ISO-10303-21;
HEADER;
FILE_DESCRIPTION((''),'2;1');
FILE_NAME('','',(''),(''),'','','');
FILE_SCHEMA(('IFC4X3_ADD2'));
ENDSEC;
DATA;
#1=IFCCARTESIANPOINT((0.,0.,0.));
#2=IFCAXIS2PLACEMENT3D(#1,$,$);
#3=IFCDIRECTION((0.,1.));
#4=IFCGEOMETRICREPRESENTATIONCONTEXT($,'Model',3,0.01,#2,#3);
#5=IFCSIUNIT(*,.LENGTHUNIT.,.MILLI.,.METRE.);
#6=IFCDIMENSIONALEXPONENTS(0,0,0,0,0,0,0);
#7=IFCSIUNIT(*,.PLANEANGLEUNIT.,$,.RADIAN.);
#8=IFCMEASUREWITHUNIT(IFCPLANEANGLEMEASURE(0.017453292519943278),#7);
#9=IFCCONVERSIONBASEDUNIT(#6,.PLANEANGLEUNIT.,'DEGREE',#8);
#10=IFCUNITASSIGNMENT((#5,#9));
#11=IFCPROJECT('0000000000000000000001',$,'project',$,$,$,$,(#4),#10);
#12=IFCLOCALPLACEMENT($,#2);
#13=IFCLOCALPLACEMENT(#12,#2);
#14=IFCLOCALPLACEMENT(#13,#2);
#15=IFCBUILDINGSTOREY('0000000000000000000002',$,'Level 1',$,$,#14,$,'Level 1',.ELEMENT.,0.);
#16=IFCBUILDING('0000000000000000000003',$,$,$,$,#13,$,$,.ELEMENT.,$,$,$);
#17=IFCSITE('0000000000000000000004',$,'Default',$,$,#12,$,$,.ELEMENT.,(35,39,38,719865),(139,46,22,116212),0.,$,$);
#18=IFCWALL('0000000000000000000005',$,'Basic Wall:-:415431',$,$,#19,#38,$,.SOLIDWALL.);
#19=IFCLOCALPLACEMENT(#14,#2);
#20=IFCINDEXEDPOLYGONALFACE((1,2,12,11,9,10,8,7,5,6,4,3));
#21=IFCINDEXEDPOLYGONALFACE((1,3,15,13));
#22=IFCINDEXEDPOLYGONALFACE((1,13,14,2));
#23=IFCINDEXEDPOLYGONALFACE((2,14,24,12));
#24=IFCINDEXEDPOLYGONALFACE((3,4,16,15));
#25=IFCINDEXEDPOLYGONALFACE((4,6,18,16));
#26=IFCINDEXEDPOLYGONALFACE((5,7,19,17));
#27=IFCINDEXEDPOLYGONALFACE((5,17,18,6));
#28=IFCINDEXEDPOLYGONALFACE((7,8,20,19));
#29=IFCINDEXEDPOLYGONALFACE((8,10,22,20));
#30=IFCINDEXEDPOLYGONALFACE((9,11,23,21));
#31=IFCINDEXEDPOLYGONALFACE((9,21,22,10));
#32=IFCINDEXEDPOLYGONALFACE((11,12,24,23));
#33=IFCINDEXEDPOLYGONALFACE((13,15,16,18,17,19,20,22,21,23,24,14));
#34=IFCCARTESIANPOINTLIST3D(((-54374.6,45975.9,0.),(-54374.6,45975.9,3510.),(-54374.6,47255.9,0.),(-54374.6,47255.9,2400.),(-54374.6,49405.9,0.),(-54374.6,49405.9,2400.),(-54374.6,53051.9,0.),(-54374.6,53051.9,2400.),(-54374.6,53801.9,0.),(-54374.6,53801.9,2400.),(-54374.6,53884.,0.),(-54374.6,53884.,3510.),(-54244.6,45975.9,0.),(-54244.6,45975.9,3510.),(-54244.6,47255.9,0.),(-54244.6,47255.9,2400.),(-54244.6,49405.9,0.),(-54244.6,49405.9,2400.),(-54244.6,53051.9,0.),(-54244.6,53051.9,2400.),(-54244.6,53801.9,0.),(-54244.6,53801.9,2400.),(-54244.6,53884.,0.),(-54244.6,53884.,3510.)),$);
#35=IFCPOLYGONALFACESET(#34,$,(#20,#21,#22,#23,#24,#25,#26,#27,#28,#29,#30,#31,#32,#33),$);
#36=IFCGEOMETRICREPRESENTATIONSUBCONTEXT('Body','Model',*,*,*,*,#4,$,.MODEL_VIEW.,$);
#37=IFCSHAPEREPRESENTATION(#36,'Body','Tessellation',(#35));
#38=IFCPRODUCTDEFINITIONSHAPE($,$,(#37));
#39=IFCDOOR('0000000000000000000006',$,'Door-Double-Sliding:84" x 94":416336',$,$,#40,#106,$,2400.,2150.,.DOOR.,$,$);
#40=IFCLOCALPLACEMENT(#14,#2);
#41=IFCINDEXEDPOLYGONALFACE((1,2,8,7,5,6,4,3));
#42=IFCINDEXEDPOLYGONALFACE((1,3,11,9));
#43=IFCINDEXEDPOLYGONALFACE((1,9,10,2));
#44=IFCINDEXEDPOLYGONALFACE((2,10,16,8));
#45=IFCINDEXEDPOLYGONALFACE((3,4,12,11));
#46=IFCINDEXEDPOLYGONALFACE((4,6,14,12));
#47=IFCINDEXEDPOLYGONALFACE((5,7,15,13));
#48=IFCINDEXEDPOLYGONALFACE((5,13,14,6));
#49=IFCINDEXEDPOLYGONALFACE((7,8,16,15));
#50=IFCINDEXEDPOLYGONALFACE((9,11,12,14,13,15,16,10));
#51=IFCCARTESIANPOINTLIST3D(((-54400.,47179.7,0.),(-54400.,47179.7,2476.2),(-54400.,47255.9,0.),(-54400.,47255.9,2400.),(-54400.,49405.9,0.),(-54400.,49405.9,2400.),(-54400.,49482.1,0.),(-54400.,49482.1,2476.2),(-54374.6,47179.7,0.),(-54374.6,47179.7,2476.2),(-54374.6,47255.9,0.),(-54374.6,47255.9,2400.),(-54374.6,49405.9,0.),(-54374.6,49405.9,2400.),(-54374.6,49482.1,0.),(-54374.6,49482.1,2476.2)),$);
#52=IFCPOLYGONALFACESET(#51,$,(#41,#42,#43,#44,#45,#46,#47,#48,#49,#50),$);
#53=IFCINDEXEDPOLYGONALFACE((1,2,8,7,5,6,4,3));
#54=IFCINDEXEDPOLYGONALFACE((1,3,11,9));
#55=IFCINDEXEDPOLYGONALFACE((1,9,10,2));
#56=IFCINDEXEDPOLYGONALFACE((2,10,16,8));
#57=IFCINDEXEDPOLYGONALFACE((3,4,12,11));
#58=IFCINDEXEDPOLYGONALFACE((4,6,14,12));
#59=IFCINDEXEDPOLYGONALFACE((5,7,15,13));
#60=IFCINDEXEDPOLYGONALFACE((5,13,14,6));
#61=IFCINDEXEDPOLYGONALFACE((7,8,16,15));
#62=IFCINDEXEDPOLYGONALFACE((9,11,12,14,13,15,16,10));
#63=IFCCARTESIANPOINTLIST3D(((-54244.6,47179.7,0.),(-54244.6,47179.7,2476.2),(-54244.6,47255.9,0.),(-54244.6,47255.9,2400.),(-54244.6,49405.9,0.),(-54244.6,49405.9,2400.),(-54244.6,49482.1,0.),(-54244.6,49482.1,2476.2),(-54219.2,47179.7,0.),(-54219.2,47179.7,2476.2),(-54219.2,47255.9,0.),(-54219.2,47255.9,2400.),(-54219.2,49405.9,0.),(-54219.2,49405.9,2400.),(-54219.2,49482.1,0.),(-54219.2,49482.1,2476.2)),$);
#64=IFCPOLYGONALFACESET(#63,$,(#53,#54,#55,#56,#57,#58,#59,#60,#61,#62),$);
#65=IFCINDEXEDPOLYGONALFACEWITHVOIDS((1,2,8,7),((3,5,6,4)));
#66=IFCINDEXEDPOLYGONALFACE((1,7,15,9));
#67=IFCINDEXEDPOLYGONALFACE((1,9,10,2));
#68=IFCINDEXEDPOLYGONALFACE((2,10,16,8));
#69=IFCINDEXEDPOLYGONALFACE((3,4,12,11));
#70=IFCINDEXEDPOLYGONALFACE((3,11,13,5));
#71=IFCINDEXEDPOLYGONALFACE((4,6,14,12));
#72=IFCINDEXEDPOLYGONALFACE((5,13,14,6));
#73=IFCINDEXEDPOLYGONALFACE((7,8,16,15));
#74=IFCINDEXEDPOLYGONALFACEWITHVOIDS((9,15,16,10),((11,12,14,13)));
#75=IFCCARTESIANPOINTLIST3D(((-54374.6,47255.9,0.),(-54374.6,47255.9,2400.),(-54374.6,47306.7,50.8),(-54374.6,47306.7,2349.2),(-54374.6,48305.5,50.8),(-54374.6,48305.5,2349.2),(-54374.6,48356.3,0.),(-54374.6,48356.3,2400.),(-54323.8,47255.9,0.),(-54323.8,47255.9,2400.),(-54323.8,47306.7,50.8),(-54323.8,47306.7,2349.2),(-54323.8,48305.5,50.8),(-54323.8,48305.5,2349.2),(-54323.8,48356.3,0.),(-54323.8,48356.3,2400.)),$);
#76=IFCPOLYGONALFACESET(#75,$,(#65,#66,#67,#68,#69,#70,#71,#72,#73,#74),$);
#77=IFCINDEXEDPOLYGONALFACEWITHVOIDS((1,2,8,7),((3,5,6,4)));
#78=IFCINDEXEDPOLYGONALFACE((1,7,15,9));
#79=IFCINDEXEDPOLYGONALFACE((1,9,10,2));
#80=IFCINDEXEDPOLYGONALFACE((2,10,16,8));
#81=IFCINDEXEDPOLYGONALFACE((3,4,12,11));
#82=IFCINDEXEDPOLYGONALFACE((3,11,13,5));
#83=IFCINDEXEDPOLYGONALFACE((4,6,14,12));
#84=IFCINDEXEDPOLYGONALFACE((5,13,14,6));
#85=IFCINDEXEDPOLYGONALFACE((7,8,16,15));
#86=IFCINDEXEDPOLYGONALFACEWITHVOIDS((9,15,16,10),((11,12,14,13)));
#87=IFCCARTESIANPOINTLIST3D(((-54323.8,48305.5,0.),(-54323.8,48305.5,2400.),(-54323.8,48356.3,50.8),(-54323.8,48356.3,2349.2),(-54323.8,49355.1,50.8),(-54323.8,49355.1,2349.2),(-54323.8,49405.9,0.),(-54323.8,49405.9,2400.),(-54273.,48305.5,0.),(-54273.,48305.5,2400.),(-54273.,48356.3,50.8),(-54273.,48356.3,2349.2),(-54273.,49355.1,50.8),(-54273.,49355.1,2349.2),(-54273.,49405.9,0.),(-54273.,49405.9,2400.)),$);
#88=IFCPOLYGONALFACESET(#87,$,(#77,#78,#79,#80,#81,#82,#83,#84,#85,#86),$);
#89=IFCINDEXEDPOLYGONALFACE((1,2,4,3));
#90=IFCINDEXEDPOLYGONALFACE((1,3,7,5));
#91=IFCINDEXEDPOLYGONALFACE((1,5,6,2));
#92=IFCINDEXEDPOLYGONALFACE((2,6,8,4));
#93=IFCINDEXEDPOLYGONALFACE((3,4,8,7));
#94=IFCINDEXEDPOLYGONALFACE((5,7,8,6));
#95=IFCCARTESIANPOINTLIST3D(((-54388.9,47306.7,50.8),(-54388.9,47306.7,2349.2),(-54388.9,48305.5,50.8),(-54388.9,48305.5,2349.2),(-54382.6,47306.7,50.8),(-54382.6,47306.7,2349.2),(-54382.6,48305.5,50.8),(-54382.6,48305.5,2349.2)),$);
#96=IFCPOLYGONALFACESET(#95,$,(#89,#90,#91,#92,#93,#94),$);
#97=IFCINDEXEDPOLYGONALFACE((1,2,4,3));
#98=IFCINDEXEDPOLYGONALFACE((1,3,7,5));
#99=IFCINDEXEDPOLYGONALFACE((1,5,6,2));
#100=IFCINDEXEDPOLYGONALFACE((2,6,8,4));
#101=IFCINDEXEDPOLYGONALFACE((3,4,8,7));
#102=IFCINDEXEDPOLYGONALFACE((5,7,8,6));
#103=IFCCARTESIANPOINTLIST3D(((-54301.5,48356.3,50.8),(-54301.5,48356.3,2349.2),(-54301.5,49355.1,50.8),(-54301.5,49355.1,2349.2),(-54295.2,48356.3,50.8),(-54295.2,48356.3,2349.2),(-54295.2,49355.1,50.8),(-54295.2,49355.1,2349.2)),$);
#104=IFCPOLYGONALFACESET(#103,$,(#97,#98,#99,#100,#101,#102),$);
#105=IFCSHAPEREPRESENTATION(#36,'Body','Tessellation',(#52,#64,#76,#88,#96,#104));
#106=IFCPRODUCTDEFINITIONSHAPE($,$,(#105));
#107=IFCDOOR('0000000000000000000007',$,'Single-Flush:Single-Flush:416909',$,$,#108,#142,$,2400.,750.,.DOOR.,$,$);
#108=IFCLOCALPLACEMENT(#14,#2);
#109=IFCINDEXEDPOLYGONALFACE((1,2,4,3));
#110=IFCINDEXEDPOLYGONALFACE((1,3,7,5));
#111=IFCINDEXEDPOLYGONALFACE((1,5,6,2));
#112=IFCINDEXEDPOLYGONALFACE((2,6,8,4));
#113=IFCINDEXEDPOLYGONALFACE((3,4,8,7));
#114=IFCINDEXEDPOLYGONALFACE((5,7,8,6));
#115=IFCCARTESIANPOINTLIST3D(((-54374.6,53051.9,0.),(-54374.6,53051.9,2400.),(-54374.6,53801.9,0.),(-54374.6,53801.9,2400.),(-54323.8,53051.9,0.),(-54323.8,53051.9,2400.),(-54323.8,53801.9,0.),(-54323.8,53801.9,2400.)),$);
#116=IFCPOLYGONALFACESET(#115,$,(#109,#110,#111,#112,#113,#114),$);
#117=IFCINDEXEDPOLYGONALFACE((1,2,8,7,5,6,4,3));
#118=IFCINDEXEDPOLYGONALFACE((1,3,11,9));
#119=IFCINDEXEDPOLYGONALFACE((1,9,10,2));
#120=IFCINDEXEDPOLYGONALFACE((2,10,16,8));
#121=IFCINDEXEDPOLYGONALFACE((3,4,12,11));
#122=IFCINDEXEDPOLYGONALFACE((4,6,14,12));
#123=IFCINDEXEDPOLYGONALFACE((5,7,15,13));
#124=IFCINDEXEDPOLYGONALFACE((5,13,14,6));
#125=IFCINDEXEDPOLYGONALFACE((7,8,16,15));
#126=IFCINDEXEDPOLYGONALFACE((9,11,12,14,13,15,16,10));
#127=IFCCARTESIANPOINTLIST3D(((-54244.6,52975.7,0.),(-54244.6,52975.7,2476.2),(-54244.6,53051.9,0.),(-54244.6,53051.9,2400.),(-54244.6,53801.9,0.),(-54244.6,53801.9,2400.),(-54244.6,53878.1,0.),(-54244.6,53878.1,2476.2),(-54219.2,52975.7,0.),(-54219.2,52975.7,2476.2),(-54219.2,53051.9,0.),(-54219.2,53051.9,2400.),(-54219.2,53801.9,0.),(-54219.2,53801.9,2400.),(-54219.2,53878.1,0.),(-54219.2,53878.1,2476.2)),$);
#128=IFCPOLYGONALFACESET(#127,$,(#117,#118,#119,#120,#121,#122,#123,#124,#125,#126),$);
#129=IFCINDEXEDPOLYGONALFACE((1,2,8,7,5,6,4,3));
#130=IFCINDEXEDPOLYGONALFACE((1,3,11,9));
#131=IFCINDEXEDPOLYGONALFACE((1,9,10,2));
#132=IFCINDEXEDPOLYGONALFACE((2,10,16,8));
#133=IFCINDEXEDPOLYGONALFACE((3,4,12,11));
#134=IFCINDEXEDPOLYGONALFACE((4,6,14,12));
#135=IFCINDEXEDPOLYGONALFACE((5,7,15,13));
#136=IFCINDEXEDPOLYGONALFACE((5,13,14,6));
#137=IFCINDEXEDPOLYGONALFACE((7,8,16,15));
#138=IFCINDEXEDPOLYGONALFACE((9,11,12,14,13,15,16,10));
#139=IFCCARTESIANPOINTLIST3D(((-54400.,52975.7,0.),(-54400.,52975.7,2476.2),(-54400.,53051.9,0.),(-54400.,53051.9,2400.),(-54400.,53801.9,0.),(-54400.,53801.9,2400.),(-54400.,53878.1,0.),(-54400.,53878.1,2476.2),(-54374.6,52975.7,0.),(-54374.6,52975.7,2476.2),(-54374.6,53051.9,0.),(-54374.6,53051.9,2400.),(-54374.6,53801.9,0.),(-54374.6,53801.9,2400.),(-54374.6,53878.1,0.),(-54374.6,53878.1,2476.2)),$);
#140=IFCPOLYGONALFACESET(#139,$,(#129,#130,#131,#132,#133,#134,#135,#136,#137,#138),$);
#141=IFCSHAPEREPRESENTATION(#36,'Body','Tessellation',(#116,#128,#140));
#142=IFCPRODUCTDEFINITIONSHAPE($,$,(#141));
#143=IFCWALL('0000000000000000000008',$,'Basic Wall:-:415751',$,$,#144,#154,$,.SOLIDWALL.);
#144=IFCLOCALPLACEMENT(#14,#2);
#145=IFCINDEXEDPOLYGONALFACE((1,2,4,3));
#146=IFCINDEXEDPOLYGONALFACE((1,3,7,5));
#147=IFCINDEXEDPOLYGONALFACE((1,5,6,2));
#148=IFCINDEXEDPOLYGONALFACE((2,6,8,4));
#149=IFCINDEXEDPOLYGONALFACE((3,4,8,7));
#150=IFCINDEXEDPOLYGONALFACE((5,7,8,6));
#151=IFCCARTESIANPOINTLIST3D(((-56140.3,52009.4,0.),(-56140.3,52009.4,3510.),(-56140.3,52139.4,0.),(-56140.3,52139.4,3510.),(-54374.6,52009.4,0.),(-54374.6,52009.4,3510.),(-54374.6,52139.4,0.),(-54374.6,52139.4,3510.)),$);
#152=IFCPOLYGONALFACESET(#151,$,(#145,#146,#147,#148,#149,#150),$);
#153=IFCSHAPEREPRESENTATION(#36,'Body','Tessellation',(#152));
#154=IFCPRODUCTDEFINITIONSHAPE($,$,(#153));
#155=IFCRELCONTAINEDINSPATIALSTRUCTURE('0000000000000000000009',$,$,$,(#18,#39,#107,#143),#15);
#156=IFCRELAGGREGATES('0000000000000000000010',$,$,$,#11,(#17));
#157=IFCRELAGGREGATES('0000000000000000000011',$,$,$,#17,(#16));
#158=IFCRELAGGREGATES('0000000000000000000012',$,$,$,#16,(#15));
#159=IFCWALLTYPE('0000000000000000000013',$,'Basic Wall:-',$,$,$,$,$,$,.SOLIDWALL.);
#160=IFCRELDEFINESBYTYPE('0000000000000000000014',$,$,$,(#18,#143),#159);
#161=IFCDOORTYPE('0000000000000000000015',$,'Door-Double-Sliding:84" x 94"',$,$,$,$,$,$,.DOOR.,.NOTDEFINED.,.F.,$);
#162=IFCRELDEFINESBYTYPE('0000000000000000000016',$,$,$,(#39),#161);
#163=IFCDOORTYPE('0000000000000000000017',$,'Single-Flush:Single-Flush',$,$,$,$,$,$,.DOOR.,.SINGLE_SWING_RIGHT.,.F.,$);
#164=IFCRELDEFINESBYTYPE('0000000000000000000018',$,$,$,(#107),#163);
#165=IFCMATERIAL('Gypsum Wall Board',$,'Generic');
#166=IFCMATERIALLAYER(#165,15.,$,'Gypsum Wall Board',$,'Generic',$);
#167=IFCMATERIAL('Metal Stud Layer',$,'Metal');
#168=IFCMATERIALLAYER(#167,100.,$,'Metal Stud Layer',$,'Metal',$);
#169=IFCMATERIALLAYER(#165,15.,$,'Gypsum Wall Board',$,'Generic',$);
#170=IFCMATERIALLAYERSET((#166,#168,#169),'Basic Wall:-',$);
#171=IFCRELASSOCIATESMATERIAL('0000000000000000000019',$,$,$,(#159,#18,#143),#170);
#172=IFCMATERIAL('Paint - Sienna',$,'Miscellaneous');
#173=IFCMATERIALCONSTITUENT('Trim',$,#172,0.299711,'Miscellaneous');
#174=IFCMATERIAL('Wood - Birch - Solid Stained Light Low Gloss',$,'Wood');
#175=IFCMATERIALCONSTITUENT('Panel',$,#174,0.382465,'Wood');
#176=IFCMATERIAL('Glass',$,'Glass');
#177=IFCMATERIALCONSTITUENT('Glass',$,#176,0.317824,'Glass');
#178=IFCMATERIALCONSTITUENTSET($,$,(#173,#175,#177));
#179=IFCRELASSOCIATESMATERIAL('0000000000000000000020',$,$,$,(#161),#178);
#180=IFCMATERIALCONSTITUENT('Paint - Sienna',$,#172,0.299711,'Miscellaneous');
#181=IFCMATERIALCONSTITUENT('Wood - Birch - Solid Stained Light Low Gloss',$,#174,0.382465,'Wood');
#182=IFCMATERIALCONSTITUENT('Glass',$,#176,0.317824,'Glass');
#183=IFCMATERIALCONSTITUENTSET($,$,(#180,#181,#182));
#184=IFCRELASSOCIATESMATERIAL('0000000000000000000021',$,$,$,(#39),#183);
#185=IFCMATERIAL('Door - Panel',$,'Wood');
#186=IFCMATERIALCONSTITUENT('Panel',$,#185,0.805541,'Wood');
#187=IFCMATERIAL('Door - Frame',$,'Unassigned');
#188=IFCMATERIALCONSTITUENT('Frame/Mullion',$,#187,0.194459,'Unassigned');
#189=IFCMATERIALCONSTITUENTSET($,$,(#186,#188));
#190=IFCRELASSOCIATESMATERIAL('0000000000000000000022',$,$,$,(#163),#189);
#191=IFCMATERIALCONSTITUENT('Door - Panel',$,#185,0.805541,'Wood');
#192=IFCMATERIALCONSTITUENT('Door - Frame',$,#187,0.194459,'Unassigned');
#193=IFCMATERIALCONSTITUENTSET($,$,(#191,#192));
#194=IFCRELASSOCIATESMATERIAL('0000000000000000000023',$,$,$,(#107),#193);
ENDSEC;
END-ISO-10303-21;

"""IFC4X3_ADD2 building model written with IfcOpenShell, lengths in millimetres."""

from ifc_helpers import new_model, entity, si_unit, converted_unit, direction, frame, frame_2d, origin, origin_2d_with_axis, place, context, subcontext, project, spatial, polyline, rectangle, outline, extrude, source, transform, mapped, material, layer, layer_set, constituent, constituent_set, type_object, type_shapes, element, fill, save


model = new_model("IFC4X3_ADD2")

# Units and contexts
model_context = context("Model", 3, precision=0.01, world=origin(), true_north=direction((0.0, 1.0)))
body_context = subcontext(model_context, "Body", "Model", "MODEL_VIEW")
ifc_project = project(units=[si_unit("LENGTHUNIT", "METRE", prefix="MILLI"), converted_unit("PLANEANGLEUNIT", "DEGREE", entity("IfcPlaneAngleMeasure", 0.017453292519943278), si_unit("PLANEANGLEUNIT", "RADIAN"), dimensions=[0, 0, 0, 0, 0, 0, 0])], contexts=[model_context])

# Site, building, storey
site_placement = place(None, origin())
site = spatial("IfcSite", under=ifc_project, at=site_placement, Name="Default", CompositionType="ELEMENT", RefLatitude=(35, 39, 38, 719865), RefLongitude=(139, 46, 22, 116212), RefElevation=0.0)
building_placement = place(site_placement, origin())
building = spatial("IfcBuilding", under=site, at=building_placement, CompositionType="ELEMENT")
storey_placement = place(building_placement, origin())
storey = spatial("IfcBuildingStorey", under=building, at=storey_placement, Name="Level 1", LongName="Level 1", CompositionType="ELEMENT", Elevation=0.0)

# Shared definitions
ifc_material_1 = material(Name="Glass", Category="Glass")

# Wall, openings, doors
ifc_material_2 = material(Name="Gypsum Wall Board", Category="Generic")
ifc_layer_1 = layer(ifc_material_2, 15.0, Name="Gypsum Wall Board", Category="Generic")
ifc_material_3 = material(Name="Metal Stud Layer", Category="Metal")
ifc_layer_2 = layer(ifc_material_3, 100.0, Name="Metal Stud Layer", Category="Metal")
ifc_layer_3 = layer(ifc_material_2, 15.0, Name="Gypsum Wall Board", Category="Generic")
ifc_layer_set_1 = layer_set([ifc_layer_1, ifc_layer_2, ifc_layer_3], Name="Basic Wall:-")
wall_type = type_object("IfcWallType", Name="Basic Wall:-", PredefinedType="SOLIDWALL", material=ifc_layer_set_1)
wall_1_placement = place(storey_placement, frame((-54309.6, 45975.9, 0.0), z_axis=(0.0, 0.0, 1.0), x_axis=(0.0, 1.0, 0.0)))
wall_1 = element("IfcWall", 1, at=wall_1_placement, inside=storey, type_object=wall_type, material=ifc_layer_set_1, Name="Basic Wall:-:415431", PredefinedType="SOLIDWALL", context=body_context, shape_type="SweptSolid", body=[
    extrude(rectangle(XDim=7908.1, YDim=130.0, at=frame_2d((3954.1, 0.0), x_axis=(-1.0, 0.0))), origin(), (0.0, 0.0, 1.0), 3510.0),
])
opening_1_placement = place(wall_1_placement, frame((1280.0, -65.0, 0.0)))
opening_1 = element("IfcOpeningElement", 2, at=opening_1_placement, cuts=wall_1, PredefinedType="OPENING", context=body_context, shape_type="SweptSolid", body=[
    extrude(rectangle(XDim=2400.0, YDim=2150.0, at=frame_2d((1200.0, 1075.0), x_axis=(-1.0, 0.0))), frame((0.0, 0.0, 0.0), z_axis=(0.0, 1.0, 0.0), x_axis=(0.0, 0.0, 1.0)), (0.0, 0.0, 1.0), 130.0),
])
opening_2_placement = place(wall_1_placement, frame((7075.9, -65.0, 0.0)))
opening_2 = element("IfcOpeningElement", 3, at=opening_2_placement, cuts=wall_1, PredefinedType="OPENING", context=body_context, shape_type="SweptSolid", body=[
    extrude(rectangle(XDim=750.0, YDim=2400.0, at=frame_2d((1200.0, 375.0), x_axis=(0.0, 1.0))), frame((0.0, 0.0, 0.0), z_axis=(0.0, 1.0, 0.0), x_axis=(0.0, 0.0, 1.0)), (0.0, 0.0, 1.0), 130.0),
])
ifc_material_4 = material(Name="Paint - Sienna", Category="Miscellaneous")
ifc_constituent_1 = constituent(ifc_material_4, Name="Paint - Sienna", Category="Miscellaneous", fraction=0.299711)
ifc_material_5 = material(Name="Wood - Birch - Solid Stained Light Low Gloss", Category="Wood")
ifc_constituent_2 = constituent(ifc_material_5, Name="Wood - Birch - Solid Stained Light Low Gloss", Category="Wood", fraction=0.382465)
ifc_constituent_3 = constituent(ifc_material_1, Name="Glass", Category="Glass", fraction=0.317824)
ifc_constituent_set_1 = constituent_set(constituents=[ifc_constituent_1, ifc_constituent_2, ifc_constituent_3])
ifc_constituent_4 = constituent(ifc_material_4, Name="Trim", Category="Miscellaneous", fraction=0.299711)
ifc_constituent_5 = constituent(ifc_material_5, Name="Panel", Category="Wood", fraction=0.382465)
ifc_constituent_6 = constituent(ifc_material_1, Name="Glass", Category="Glass", fraction=0.317824)
ifc_constituent_set_2 = constituent_set(constituents=[ifc_constituent_4, ifc_constituent_5, ifc_constituent_6])
door_type_1 = type_object("IfcDoorType", Name="Door-Double-Sliding:84\" x 94\"", OperationType="NOTDEFINED", ParameterTakesPrecedence=False, PredefinedType="DOOR", material=ifc_constituent_set_2)
shared_shape_1 = source(origin(), body_context, "Body", "SweptSolid", [
    extrude(outline(polyline([(-1151.2, -1219.0), (-1075.0, -1219.0), (-1075.0, 1181.0), (1075.0, 1180.9), (1075.0, -1219.1), (1151.2, -1219.1), (1151.2, 1257.1), (-1151.2, 1257.2), (-1151.2, -1219.0)])), frame((1075.0, 130.0, 1219.0), z_axis=(0.0, 1.0, 0.0), x_axis=(-1.0, 0.0, 0.0)), (0.0, 0.0, 1.0), 25.4),
    extrude(outline(polyline([(-1219.0, -1151.2), (1257.1, -1151.2), (1257.1, 1151.2), (-1219.0, 1151.2), (-1219.0, 1075.0), (1180.9, 1075.0), (1180.9, -1075.0), (-1219.0, -1075.0), (-1219.0, -1151.2)])), frame((1075.0, -25.4, 1219.0), z_axis=(0.0, 1.0, 0.0), x_axis=(0.0, 0.0, 1.0)), (0.0, 0.0, 1.0), 25.4),
    extrude(outline(polyline([(-1200.0, -550.2), (1200.0, -550.2), (1200.0, 550.2), (-1200.0, 550.2), (-1200.0, -550.2)]), holes=[polyline([(-1149.2, -499.4), (-1149.2, 499.4), (1149.2, 499.4), (1149.2, -499.4), (-1149.2, -499.4)])]), frame((550.2, 79.2, 1200.0), z_axis=(0.0, 1.0, 0.0), x_axis=(0.0, 0.0, -1.0)), (0.0, 0.0, 1.0), 50.8),
    extrude(outline(polyline([(-550.2, -1200.0), (550.2, -1200.0), (550.2, 1200.0), (-550.2, 1200.0), (-550.2, -1200.0)]), holes=[polyline([(-499.4, -1149.2), (-499.4, 1149.2), (499.4, 1149.2), (499.4, -1149.2), (-499.4, -1149.2)])]), frame((1599.8, 28.4, 1200.0), z_axis=(0.0, 1.0, 0.0), x_axis=(1.0, 0.0, 0.0)), (0.0, 0.0, 1.0), 50.8),
    extrude(rectangle(XDim=6.4, YDim=998.8, at=origin_2d_with_axis()), frame((550.2, 141.2, 50.8), z_axis=(0.0, 0.0, 1.0), x_axis=(0.0, 1.0, 0.0)), (0.0, 0.0, 1.0), 2298.4),
    extrude(rectangle(XDim=6.3, YDim=998.8, at=frame_2d((0.0, 0.0), x_axis=(1.0, 0.0))), frame((1599.8, 53.8, 50.8), z_axis=(0.0, 0.0, 1.0), x_axis=(0.0, -1.0, 0.0)), (0.0, 0.0, 1.0), 2298.4),
])
type_shapes(door_type_1, [shared_shape_1])
door_1_placement = place(opening_1_placement, origin())
door_1 = element("IfcDoor", 4, at=door_1_placement, inside=storey, type_object=door_type_1, material=ifc_constituent_set_1, Name="Door-Double-Sliding:84\" x 94\":416336", OverallHeight=2400.0, OverallWidth=2150.0, PredefinedType="DOOR", context=body_context, shape_type="MappedRepresentation", body=[
    mapped(shared_shape_1, transform((0.0, 0.0, 0.0), scale=1.0)),
])
fill(opening_1, door_1)
ifc_material_6 = material(Name="Door - Panel", Category="Wood")
ifc_constituent_7 = constituent(ifc_material_6, Name="Door - Panel", Category="Wood", fraction=0.805541)
ifc_material_7 = material(Name="Door - Frame", Category="Unassigned")
ifc_constituent_8 = constituent(ifc_material_7, Name="Door - Frame", Category="Unassigned", fraction=0.194459)
ifc_constituent_set_3 = constituent_set(constituents=[ifc_constituent_7, ifc_constituent_8])
ifc_constituent_9 = constituent(ifc_material_6, Name="Panel", Category="Wood", fraction=0.805541)
ifc_constituent_10 = constituent(ifc_material_7, Name="Frame/Mullion", Category="Unassigned", fraction=0.194459)
ifc_constituent_set_4 = constituent_set(constituents=[ifc_constituent_9, ifc_constituent_10])
door_type_2 = type_object("IfcDoorType", Name="Single-Flush:Single-Flush", OperationType="SINGLE_SWING_RIGHT", ParameterTakesPrecedence=False, PredefinedType="DOOR", material=ifc_constituent_set_4)
shared_shape_2 = source(origin(), body_context, "Body", "SweptSolid", [
    extrude(rectangle(XDim=50.8, YDim=750.0, at=frame_2d((0.0, 0.0), x_axis=(1.0, 0.0))), frame((375.0, 104.6, 0.0), z_axis=(0.0, 0.0, 1.0), x_axis=(0.0, 1.0, 0.0)), (0.0, 0.0, 1.0), 2400.0),
    extrude(outline(polyline([(-1257.1, -451.2), (1219.0, -451.2), (1219.0, -375.0), (-1180.9, -375.0), (-1180.9, 375.0), (1219.0, 375.0), (1219.0, 451.2), (-1257.1, 451.2), (-1257.1, -451.2)])), frame((375.0, -25.4, 1219.0), z_axis=(0.0, 1.0, 0.0), x_axis=(0.0, 0.0, -1.0)), (0.0, 0.0, 1.0), 25.4),
    extrude(outline(polyline([(-451.2, -1257.1), (451.2, -1257.1), (451.2, 1219.1), (375.0, 1219.1), (375.0, -1181.0), (-375.0, -1181.0), (-375.0, 1219.1), (-451.2, 1219.1), (-451.2, -1257.1)])), frame((375.0, 130.0, 1219.1), z_axis=(0.0, 1.0, 0.0), x_axis=(1.0, 0.0, 0.0)), (0.0, 0.0, 1.0), 25.4),
])
type_shapes(door_type_2, [shared_shape_2])
door_2_placement = place(opening_2_placement, origin())
door_2 = element("IfcDoor", 5, at=door_2_placement, inside=storey, type_object=door_type_2, material=ifc_constituent_set_3, Name="Single-Flush:Single-Flush:416909", OverallHeight=2400.0, OverallWidth=750.0, PredefinedType="DOOR", context=body_context, shape_type="MappedRepresentation", body=[
    mapped(shared_shape_2, transform((0.0, 0.0, 0.0), scale=1.0)),
])
fill(opening_2, door_2)

# Wall
wall_2_placement = place(storey_placement, frame((-54374.6, 52074.4, 0.0), z_axis=(0.0, 0.0, 1.0), x_axis=(-1.0, 0.0, 0.0)))
element("IfcWall", 6, at=wall_2_placement, inside=storey, type_object=wall_type, material=ifc_layer_set_1, Name="Basic Wall:-:415751", PredefinedType="SOLIDWALL", context=body_context, shape_type="SweptSolid", body=[
    extrude(rectangle(XDim=1765.7, YDim=130.0, at=frame_2d((882.9, 0.0), x_axis=(-1.0, 0.0))), origin(), (0.0, 0.0, 1.0), 3510.0),
])

save(model, "model.ifc")
